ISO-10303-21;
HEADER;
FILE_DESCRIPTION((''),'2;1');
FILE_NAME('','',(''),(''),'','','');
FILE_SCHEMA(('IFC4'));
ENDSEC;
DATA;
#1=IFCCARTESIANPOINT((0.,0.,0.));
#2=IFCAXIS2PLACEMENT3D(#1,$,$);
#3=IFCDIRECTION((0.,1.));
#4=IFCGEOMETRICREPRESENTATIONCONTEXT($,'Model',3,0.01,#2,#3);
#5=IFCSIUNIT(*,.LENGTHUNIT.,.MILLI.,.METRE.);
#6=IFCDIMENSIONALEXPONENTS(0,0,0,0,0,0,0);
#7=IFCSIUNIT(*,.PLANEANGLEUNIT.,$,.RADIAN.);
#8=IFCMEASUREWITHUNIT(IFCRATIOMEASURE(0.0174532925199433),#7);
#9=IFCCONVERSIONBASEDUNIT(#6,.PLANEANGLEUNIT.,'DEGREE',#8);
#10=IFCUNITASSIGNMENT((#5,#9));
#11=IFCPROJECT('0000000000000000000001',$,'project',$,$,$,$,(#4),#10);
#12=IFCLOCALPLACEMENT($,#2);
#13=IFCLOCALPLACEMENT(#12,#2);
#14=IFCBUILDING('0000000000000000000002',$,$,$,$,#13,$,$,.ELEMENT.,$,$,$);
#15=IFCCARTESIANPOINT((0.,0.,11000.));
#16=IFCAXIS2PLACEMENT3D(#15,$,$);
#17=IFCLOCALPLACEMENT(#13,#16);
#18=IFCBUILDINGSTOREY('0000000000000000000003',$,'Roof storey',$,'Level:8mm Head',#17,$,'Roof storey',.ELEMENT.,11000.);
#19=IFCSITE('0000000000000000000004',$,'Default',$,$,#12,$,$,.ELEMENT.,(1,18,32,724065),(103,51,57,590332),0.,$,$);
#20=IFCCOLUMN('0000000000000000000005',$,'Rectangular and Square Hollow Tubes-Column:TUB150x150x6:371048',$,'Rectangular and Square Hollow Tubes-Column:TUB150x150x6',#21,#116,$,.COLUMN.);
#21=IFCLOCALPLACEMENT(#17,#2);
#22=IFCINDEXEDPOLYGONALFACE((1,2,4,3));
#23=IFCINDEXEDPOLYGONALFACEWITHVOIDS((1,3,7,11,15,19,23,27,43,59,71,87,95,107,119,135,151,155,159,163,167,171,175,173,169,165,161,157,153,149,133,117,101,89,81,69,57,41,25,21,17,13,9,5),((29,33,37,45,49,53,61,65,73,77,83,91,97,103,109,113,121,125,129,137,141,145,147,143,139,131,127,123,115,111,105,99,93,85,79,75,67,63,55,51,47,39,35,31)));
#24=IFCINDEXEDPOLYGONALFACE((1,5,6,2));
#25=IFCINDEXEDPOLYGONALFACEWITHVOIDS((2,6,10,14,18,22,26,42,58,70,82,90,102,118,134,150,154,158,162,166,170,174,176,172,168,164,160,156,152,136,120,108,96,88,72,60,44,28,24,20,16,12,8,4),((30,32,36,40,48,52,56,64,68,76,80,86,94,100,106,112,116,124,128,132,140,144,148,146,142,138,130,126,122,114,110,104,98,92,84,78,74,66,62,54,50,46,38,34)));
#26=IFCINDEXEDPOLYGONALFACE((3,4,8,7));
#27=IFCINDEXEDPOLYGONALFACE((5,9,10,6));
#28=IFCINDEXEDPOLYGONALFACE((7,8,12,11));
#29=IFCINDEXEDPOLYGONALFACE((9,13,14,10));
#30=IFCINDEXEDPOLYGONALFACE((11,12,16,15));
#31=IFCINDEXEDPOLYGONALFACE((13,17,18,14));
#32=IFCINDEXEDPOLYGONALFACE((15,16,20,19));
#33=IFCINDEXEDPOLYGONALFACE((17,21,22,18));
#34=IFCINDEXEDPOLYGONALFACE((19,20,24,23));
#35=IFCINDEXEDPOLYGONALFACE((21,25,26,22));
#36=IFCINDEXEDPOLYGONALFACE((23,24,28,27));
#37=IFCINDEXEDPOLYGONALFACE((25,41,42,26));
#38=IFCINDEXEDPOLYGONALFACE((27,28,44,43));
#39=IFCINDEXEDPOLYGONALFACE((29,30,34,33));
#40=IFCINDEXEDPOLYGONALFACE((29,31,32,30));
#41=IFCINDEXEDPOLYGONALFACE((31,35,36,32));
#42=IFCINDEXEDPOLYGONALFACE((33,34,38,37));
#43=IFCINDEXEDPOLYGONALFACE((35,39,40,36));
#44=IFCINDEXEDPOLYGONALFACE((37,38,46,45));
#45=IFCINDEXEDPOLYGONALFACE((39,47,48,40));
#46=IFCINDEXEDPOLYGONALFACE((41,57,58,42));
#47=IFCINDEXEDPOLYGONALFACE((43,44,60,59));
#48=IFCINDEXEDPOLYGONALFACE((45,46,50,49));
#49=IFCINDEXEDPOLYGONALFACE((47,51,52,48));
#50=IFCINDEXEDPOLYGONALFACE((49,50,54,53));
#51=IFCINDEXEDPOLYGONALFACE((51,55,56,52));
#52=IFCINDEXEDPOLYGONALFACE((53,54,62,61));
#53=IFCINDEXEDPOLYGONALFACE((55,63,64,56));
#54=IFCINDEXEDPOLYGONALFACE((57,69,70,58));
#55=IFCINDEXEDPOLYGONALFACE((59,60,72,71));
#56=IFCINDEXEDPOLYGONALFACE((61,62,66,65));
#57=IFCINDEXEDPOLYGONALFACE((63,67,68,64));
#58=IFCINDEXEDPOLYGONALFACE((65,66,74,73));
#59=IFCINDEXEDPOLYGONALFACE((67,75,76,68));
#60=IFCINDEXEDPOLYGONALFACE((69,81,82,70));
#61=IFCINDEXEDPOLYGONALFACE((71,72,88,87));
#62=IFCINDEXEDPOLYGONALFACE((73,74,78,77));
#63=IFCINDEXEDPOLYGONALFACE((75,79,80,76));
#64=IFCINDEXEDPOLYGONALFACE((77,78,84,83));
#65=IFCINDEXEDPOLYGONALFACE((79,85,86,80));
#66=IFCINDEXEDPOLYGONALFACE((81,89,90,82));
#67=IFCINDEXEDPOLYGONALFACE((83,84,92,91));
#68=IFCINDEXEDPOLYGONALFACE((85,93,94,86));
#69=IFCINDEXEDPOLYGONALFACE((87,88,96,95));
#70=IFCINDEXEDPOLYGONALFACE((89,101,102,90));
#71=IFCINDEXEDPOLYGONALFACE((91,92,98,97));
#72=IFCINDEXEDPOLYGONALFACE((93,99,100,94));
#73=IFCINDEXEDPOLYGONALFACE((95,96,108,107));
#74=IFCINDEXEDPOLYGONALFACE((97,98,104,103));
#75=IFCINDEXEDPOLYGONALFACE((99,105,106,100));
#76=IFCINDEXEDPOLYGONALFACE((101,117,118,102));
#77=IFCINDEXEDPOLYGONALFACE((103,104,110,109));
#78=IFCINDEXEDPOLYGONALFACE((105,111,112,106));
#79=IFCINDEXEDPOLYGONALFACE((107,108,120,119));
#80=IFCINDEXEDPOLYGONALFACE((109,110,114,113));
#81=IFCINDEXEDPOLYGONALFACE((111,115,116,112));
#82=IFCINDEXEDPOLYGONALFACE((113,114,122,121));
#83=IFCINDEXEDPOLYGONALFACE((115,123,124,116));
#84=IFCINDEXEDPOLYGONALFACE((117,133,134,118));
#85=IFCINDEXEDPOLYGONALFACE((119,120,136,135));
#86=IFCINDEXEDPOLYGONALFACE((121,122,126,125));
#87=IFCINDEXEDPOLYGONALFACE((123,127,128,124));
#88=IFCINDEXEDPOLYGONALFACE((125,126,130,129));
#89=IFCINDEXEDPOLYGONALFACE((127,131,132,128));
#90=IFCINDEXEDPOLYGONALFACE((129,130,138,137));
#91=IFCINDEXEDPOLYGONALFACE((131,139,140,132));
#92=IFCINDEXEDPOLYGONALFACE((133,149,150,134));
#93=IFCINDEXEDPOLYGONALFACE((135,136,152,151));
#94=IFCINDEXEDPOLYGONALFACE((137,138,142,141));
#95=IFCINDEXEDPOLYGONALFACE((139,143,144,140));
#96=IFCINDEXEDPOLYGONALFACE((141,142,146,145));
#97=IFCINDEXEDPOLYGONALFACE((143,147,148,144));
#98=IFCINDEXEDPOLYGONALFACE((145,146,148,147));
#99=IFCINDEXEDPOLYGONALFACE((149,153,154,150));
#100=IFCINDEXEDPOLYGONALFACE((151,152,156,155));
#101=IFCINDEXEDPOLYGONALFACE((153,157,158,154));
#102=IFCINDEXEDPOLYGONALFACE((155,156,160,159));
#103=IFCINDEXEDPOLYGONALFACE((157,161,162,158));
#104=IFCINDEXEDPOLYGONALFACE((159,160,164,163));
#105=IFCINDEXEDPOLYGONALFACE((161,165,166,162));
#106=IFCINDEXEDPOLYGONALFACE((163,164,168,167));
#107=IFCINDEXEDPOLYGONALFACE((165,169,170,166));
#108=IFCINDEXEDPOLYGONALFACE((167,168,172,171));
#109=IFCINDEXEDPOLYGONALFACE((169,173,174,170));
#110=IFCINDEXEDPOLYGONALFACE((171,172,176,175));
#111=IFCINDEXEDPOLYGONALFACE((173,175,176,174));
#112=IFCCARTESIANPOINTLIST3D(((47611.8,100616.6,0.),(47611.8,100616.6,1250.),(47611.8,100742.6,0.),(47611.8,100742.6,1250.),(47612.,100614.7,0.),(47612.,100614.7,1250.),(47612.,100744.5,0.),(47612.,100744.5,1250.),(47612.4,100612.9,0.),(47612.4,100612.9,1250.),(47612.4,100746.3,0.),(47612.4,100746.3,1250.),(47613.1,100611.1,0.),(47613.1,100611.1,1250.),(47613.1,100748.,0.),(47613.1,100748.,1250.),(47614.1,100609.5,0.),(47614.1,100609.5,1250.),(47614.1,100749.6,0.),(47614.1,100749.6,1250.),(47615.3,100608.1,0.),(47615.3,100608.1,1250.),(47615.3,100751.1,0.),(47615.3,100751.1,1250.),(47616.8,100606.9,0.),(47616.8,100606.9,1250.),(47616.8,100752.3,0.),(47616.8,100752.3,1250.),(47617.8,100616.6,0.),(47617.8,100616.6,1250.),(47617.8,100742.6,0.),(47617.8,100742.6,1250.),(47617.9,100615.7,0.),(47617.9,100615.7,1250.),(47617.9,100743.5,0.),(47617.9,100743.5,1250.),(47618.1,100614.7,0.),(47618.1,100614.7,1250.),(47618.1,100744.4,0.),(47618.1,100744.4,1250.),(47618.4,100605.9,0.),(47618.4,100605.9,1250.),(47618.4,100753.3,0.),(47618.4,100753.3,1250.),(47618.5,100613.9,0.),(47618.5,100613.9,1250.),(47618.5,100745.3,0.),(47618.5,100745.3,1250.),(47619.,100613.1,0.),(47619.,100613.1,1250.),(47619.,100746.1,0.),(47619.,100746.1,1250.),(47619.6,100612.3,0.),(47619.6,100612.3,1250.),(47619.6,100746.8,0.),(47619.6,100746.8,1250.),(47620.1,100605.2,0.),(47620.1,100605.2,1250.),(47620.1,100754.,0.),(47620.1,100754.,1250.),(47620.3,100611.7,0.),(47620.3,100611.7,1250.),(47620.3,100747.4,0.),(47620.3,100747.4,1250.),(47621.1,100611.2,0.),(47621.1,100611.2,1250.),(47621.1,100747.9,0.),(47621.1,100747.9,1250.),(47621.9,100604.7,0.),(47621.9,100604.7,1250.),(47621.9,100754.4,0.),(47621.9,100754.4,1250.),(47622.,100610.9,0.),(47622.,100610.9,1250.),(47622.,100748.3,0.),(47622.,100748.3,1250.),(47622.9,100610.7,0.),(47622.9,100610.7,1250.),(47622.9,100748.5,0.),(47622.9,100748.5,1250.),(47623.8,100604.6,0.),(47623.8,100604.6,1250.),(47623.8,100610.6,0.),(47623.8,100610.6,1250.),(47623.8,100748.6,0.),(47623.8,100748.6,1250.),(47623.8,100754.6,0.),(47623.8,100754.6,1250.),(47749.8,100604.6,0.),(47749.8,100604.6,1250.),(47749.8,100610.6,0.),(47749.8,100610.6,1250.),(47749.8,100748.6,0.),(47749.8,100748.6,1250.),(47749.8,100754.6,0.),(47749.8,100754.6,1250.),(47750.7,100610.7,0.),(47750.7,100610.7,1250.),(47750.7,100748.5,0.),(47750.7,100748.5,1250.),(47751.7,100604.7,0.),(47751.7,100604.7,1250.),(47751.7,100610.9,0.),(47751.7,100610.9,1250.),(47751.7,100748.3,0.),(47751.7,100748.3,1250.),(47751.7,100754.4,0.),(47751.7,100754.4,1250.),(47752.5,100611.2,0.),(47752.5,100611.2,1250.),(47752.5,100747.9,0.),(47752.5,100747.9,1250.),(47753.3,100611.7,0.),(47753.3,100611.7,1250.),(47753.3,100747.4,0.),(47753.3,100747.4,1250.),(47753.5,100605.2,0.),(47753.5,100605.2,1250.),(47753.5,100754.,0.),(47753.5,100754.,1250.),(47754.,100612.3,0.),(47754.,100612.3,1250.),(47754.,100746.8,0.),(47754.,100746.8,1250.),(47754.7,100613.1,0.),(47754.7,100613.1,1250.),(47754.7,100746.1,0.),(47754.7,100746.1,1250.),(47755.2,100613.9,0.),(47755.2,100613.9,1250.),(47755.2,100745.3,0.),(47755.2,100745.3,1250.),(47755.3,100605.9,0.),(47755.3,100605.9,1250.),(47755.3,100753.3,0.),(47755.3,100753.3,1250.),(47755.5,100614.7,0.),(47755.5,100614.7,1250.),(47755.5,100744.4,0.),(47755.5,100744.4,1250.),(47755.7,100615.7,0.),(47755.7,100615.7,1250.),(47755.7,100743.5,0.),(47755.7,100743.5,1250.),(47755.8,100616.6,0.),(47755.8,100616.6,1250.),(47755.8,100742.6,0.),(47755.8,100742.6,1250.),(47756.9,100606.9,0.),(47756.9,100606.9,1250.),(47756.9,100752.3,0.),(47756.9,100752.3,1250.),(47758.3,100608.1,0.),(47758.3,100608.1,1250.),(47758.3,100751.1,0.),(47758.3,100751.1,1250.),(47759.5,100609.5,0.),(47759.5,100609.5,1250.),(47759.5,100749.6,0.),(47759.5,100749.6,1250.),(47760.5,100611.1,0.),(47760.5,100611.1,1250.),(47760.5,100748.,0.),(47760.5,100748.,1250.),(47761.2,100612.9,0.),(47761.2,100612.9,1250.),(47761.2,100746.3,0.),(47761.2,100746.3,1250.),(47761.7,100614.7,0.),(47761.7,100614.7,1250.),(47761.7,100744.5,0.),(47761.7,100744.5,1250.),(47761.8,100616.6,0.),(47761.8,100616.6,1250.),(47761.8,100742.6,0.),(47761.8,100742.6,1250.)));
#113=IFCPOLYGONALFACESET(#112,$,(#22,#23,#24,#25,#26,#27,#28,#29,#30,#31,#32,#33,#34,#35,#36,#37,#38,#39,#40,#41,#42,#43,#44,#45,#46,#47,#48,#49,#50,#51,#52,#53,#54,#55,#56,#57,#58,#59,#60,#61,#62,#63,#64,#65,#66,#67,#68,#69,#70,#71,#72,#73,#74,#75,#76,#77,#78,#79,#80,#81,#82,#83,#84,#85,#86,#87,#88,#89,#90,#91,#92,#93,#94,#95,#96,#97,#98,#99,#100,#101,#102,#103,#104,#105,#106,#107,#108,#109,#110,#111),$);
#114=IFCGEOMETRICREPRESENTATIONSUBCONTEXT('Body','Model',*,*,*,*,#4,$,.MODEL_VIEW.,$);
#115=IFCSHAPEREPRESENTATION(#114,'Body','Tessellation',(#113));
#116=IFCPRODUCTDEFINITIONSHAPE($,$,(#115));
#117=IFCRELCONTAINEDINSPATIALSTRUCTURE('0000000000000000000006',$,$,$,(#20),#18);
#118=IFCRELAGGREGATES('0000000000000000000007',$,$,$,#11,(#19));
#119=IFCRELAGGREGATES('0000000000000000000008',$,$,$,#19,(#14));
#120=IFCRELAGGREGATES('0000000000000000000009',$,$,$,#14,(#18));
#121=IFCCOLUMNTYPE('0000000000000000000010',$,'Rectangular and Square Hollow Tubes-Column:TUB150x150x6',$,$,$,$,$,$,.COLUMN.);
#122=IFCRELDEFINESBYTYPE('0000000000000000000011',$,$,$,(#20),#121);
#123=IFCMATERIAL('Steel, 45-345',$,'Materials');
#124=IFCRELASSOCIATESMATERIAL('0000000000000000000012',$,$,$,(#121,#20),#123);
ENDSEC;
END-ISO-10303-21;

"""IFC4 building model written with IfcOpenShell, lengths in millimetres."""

from ifc_helpers import new_model, entity, si_unit, converted_unit, direction, frame, origin, place, context, subcontext, project, spatial, indexed_curve, outline, extrude, source, transform, mapped, material, type_object, type_shapes, element, save


model = new_model("IFC4")

# Units and contexts
model_context = context("Model", 3, precision=0.01, world=origin(), true_north=direction((0.0, 1.0)))
body_context = subcontext(model_context, "Body", "Model", "MODEL_VIEW")
ifc_project = project(units=[si_unit("LENGTHUNIT", "METRE", prefix="MILLI"), converted_unit("PLANEANGLEUNIT", "DEGREE", entity("IfcRatioMeasure", 0.0174532925199433), si_unit("PLANEANGLEUNIT", "RADIAN"), dimensions=[0, 0, 0, 0, 0, 0, 0])], contexts=[model_context])

# Site, building, storey
site_placement = place(None, origin())
site = spatial("IfcSite", under=ifc_project, at=site_placement, Name="Default", CompositionType="ELEMENT", RefLatitude=(1, 18, 32, 724065), RefLongitude=(103, 51, 57, 590332), RefElevation=0.0)
building_placement = place(site_placement, origin())
building = spatial("IfcBuilding", under=site, at=building_placement, CompositionType="ELEMENT")
storey_placement = place(building_placement, frame((0.0, 0.0, 11000.0)))
storey = spatial("IfcBuildingStorey", under=building, at=storey_placement, Name="Roof storey", ObjectType="Level:8mm Head", LongName="Roof storey", CompositionType="ELEMENT", Elevation=11000.0)

# Column
ifc_material = material(Name="Steel, 45-345", Category="Materials")
column_type = type_object("IfcColumnType", Name="Rectangular and Square Hollow Tubes-Column:TUB150x150x6", PredefinedType="COLUMN", material=ifc_material)
shared_shape_1 = source(origin(), body_context, "Body", "SweptSolid", [
    extrude(outline(indexed_curve([(-63.0, -75.0), (63.0, -75.0), (64.9, -74.9), (66.7, -74.4), (68.4, -73.7), (70.1, -72.7), (71.5, -71.5), (72.7, -70.1), (73.7, -68.4), (74.4, -66.7), (74.9, -64.9), (75.0, -63.0), (75.0, 63.0), (74.9, 64.9), (74.4, 66.7), (73.7, 68.4), (72.7, 70.1), (71.5, 71.5), (70.1, 72.7), (68.4, 73.7), (66.7, 74.4), (64.9, 74.9), (63.0, 75.0), (-63.0, 75.0), (-64.9, 74.9), (-66.7, 74.4), (-68.4, 73.7), (-70.1, 72.7), (-71.5, 71.5), (-72.7, 70.1), (-73.7, 68.4), (-74.4, 66.7), (-74.9, 64.9), (-75.0, 63.0), (-75.0, -63.0), (-74.9, -64.9), (-74.4, -66.7), (-73.7, -68.4), (-72.7, -70.1), (-71.5, -71.5), (-70.1, -72.7), (-68.4, -73.7), (-66.7, -74.4), (-64.9, -74.9), (-63.0, -75.0)], self_intersect=False), holes=[indexed_curve([(-63.0, -69.0), (-63.9, -68.9), (-64.9, -68.7), (-65.7, -68.3), (-66.5, -67.9), (-67.2, -67.2), (-67.9, -66.5), (-68.3, -65.7), (-68.7, -64.9), (-68.9, -63.9), (-69.0, -63.0), (-69.0, 63.0), (-68.9, 63.9), (-68.7, 64.9), (-68.3, 65.7), (-67.9, 66.5), (-67.2, 67.2), (-66.5, 67.9), (-65.7, 68.3), (-64.9, 68.7), (-63.9, 68.9), (-63.0, 69.0), (63.0, 69.0), (63.9, 68.9), (64.9, 68.7), (65.7, 68.3), (66.5, 67.9), (67.2, 67.2), (67.9, 66.5), (68.3, 65.7), (68.7, 64.9), (68.9, 63.9), (69.0, 63.0), (69.0, -63.0), (68.9, -63.9), (68.7, -64.9), (68.3, -65.7), (67.9, -66.5), (67.2, -67.2), (66.5, -67.9), (65.7, -68.3), (64.9, -68.7), (63.9, -68.9), (63.0, -69.0), (-63.0, -69.0)], self_intersect=False)]), frame((0.0, 0.0, 11000.0), z_axis=(0.0, 0.0, 1.0), x_axis=(-1.0, 0.0, 0.0)), (0.0, 0.0, 1.0), 1250.0),
])
type_shapes(column_type, [shared_shape_1])
for number, where, name in (
    (1, (47686.8, 100679.6, -11000.0), "Rectangular and Square Hollow Tubes-Column:TUB150x150x6:371048"),
):
    element("IfcColumn", number, at=place(storey_placement, frame(where)), inside=storey, type_object=column_type, material=ifc_material, Name=name, ObjectType="Rectangular and Square Hollow Tubes-Column:TUB150x150x6", PredefinedType="COLUMN", context=body_context, shape_type="MappedRepresentation", body=[
        mapped(shared_shape_1, transform((0.0, 0.0, 0.0), scale=1.0)),
    ])

save(model, "model.ifc")
